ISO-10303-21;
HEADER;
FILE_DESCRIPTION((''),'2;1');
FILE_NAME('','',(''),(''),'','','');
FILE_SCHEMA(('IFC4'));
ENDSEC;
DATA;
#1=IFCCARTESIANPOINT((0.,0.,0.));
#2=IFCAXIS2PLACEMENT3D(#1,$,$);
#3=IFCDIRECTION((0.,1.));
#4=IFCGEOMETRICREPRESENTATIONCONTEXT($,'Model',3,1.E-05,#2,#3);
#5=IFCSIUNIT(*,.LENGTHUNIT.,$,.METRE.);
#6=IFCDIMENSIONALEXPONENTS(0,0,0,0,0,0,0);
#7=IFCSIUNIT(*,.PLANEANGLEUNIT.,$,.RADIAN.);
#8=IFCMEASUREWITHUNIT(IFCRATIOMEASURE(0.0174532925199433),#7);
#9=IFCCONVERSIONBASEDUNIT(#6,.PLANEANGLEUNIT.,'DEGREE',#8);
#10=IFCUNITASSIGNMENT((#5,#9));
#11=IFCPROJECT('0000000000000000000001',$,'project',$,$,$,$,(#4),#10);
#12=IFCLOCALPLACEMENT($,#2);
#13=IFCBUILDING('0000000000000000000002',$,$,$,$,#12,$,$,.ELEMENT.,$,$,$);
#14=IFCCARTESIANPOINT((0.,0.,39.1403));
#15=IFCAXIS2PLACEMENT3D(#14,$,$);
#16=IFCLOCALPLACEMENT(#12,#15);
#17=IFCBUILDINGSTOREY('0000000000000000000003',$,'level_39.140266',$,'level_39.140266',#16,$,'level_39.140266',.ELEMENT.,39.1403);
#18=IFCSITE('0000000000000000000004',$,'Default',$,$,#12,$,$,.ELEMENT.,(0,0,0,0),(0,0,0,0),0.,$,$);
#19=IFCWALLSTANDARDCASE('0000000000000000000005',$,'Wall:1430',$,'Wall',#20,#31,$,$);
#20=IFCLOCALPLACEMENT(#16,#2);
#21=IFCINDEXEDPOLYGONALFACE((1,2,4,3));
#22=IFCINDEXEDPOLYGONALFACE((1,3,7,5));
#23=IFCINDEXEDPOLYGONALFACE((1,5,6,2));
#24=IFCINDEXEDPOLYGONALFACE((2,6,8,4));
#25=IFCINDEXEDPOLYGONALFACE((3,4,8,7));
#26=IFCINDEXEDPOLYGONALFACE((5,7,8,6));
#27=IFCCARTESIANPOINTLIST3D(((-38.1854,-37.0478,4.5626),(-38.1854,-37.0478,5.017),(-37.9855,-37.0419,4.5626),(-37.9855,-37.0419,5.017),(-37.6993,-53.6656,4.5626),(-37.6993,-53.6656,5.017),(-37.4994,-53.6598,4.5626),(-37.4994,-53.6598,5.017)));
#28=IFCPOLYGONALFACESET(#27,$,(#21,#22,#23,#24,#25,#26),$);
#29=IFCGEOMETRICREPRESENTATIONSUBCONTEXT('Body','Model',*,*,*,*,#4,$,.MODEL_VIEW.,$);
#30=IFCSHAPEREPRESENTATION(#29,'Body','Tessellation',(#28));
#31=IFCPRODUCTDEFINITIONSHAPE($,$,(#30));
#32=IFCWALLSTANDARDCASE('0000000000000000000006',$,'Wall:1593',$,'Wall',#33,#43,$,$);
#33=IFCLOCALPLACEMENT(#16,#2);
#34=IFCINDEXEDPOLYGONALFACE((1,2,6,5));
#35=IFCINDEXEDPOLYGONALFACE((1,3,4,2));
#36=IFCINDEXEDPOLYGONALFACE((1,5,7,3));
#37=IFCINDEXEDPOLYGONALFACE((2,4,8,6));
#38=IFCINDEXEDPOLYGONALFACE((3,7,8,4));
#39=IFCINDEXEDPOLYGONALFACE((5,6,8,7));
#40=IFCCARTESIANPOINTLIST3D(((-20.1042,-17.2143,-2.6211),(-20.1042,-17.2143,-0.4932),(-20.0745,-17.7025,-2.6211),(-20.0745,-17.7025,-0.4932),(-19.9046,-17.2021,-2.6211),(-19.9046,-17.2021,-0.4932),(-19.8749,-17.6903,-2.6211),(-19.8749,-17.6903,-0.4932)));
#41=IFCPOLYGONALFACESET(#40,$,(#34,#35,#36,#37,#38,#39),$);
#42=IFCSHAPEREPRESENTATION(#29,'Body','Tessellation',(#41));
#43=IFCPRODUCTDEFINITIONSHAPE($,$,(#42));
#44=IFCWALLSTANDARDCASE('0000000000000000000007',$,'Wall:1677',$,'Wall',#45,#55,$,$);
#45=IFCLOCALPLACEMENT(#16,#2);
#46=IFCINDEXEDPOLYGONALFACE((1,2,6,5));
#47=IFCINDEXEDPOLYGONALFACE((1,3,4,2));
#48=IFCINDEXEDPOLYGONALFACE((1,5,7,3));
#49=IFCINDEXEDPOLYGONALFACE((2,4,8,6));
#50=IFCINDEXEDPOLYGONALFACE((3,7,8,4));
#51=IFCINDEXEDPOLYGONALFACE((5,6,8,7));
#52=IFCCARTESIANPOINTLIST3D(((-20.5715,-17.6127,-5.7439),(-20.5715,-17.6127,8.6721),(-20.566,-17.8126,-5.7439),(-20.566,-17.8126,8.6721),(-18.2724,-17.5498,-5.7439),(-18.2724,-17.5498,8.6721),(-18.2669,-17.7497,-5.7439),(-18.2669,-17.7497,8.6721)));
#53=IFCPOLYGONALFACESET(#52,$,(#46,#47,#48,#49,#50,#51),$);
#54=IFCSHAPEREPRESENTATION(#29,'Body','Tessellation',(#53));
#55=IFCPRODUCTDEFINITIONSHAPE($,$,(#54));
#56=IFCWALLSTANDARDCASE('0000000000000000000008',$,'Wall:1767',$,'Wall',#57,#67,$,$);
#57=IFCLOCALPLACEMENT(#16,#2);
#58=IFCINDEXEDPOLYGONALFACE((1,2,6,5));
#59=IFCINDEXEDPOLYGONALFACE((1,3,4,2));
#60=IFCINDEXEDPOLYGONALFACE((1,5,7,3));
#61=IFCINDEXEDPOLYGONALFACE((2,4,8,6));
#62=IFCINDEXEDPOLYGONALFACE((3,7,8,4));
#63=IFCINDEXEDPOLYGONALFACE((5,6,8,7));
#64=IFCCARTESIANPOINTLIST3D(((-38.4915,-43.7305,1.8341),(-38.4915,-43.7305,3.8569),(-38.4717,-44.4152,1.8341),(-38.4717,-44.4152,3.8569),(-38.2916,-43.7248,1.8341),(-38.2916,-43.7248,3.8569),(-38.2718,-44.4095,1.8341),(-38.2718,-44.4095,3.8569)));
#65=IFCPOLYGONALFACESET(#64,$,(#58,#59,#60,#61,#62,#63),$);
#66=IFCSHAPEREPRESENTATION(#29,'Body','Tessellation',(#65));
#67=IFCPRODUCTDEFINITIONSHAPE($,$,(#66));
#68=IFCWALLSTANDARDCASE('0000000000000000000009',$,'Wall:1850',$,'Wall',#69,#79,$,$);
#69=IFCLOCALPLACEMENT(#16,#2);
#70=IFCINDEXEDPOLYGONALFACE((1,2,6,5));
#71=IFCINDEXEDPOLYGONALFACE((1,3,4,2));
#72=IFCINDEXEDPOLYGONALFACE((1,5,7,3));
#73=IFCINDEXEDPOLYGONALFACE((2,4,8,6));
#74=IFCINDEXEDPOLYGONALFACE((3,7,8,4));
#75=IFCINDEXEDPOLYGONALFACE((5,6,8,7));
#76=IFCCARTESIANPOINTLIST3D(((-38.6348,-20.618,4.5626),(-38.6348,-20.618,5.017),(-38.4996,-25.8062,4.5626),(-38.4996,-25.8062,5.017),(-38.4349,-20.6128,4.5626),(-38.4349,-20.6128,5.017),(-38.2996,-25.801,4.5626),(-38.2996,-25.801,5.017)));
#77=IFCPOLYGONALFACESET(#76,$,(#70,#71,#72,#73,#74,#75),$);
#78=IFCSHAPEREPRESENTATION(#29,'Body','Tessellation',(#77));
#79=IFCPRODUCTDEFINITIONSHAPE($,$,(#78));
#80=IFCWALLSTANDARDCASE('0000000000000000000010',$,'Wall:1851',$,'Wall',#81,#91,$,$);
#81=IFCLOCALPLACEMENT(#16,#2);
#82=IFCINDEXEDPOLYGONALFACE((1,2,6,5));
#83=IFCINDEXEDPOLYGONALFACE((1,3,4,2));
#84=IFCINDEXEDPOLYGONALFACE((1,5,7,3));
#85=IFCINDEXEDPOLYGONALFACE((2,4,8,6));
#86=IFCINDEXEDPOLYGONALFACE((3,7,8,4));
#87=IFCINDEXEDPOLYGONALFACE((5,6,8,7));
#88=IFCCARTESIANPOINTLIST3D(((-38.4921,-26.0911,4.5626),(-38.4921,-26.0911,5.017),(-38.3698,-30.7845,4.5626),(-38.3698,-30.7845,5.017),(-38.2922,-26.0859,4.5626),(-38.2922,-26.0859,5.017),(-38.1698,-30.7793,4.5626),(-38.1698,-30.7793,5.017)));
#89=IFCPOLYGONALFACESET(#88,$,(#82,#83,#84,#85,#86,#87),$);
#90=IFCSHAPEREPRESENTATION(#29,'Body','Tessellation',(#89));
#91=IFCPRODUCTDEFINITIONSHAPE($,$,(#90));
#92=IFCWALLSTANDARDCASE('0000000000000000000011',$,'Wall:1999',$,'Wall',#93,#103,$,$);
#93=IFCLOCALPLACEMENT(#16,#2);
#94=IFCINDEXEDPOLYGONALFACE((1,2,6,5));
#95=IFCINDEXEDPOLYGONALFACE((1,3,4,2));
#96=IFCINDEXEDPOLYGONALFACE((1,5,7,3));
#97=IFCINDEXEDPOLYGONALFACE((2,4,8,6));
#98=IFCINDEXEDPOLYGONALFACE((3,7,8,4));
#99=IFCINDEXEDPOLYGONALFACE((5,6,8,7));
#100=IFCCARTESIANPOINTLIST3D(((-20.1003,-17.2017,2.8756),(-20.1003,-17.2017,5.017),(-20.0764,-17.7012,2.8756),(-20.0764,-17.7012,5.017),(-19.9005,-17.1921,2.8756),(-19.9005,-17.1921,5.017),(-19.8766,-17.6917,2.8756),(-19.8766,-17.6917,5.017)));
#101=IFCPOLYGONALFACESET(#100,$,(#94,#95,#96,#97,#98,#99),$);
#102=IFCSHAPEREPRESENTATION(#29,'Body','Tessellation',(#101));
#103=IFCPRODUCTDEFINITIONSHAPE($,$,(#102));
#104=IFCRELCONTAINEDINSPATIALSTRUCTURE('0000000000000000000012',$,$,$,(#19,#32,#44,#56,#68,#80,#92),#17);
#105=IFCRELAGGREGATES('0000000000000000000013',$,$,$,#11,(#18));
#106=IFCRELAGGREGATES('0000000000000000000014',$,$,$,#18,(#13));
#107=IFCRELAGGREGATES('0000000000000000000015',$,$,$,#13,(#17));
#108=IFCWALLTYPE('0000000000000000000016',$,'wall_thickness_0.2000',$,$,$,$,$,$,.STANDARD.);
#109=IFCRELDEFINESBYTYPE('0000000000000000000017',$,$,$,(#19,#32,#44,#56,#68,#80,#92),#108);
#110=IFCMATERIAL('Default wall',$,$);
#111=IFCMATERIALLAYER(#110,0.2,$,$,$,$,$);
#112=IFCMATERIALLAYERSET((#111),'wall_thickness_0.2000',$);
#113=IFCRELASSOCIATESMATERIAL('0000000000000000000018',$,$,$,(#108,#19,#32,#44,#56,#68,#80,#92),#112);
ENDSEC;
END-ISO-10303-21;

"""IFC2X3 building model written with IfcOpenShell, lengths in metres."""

from ifc_helpers import new_model, entity, si_unit, converted_unit, direction, frame, origin, place, context, subcontext, project, spatial, polyline, outline, extrude, material, layer, layer_set, layer_usage, type_object, element, save


model = new_model("IFC2X3")

# Units and contexts
model_context = context("Model", 3, precision=1e-05, world=origin(), true_north=direction((0.0, 1.0)))
body_context = subcontext(model_context, "Body", "Model", "MODEL_VIEW")
ifc_project = project(units=[si_unit("LENGTHUNIT", "METRE"), converted_unit("PLANEANGLEUNIT", "DEGREE", entity("IfcRatioMeasure", 0.0174532925199433), si_unit("PLANEANGLEUNIT", "RADIAN"), dimensions=[0, 0, 0, 0, 0, 0, 0])], contexts=[model_context])

# Site, building, storey
placement_1 = place(None, origin())
site = spatial("IfcSite", under=ifc_project, at=placement_1, Name="Default", CompositionType="ELEMENT", RefLatitude=(0, 0, 0, 0), RefLongitude=(0, 0, 0, 0), RefElevation=0.0)
building = spatial("IfcBuilding", under=site, at=placement_1, CompositionType="ELEMENT")
storey_placement = place(placement_1, frame((0.0, 0.0, 39.1403)))
storey = spatial("IfcBuildingStorey", under=building, at=storey_placement, Name="level_39.140266", ObjectType="level_39.140266", LongName="level_39.140266", CompositionType="ELEMENT", Elevation=39.1403)

# Shared definitions
ifc_material_1 = material(Name="Default wall")
ifc_layer = layer(ifc_material_1, 0.2)
ifc_layer_set = layer_set([ifc_layer], Name="wall_thickness_0.2000")
ifc_layer_usage = layer_usage(ifc_layer_set, "AXIS2", "POSITIVE", -0.1)
wall_type = type_object("IfcWallType", Name="wall_thickness_0.2000", PredefinedType="STANDARD", material=ifc_layer_set)

# Walls
placement_2 = place(placement_1, frame((0.0, 0.0, 43.7029)))
wall_1_placement = place(placement_2, frame((-38.0854, -37.0448, 0.0), z_axis=(0.0, 0.0, 1.0), x_axis=(0.029241, -0.999572, 0.0)))
element("IfcWallStandardCase", 1, at=wall_1_placement, inside=storey, type_object=wall_type, material=ifc_layer_usage, Name="Wall:1430", ObjectType="Wall", context=body_context, shape_type="SweptSolid", body=[
    extrude(outline(polyline([(16.625, -0.1), (16.625, 0.1), (0.0, 0.1), (0.0, -0.1), (16.625, -0.1)])), origin(), (0.0, 0.0, 1.0), 0.4544),
])
placement_3 = place(placement_1, frame((0.0, 0.0, 36.5192)))
wall_2_placement = place(placement_3, frame((-19.9747, -17.6964, 0.0), z_axis=(0.0, 0.0, 1.0), x_axis=(-0.060737, 0.998154, 0.0)))
element("IfcWallStandardCase", 2, at=wall_2_placement, inside=storey, type_object=wall_type, material=ifc_layer_usage, Name="Wall:1593", ObjectType="Wall", context=body_context, shape_type="SweptSolid", body=[
    extrude(outline(polyline([(0.4891, -0.1), (0.4891, 0.1), (0.0, 0.1), (0.0, -0.1), (0.4891, -0.1)])), origin(), (0.0, 0.0, 1.0), 2.1279),
])
placement_4 = place(placement_1, frame((0.0, 0.0, 33.3964)))
wall_3_placement = place(placement_4, frame((-18.2696, -17.6497, 0.0), z_axis=(0.0, 0.0, 1.0), x_axis=(-0.999625, -0.027366, 0.0)))
element("IfcWallStandardCase", 3, at=wall_3_placement, inside=storey, type_object=wall_type, material=ifc_layer_usage, Name="Wall:1677", ObjectType="Wall", context=body_context, shape_type="SweptSolid", body=[
    extrude(outline(polyline([(2.3, -0.1), (2.3, 0.1), (0.0, 0.1), (0.0, -0.1), (2.3, -0.1)])), origin(), (0.0, 0.0, 1.0), 14.416),
])
placement_5 = place(placement_1, frame((0.0, 0.0, 40.9744)))
wall_4_placement = place(placement_5, frame((-38.3718, -44.4124, 0.0), z_axis=(0.0, 0.0, 1.0), x_axis=(-0.028836, 0.999584, 0.0)))
element("IfcWallStandardCase", 4, at=wall_4_placement, inside=storey, type_object=wall_type, material=ifc_layer_usage, Name="Wall:1767", ObjectType="Wall", context=body_context, shape_type="SweptSolid", body=[
    extrude(outline(polyline([(0.685, -0.1), (0.685, 0.1), (0.0, 0.1), (0.0, -0.1), (0.685, -0.1)])), origin(), (0.0, 0.0, 1.0), 2.0228),
])
placement_6 = place(placement_1, frame((0.0, 0.0, 43.7029)))
wall_5_placement = place(placement_6, frame((-38.5349, -20.6154, 0.0), z_axis=(0.0, 0.0, 1.0), x_axis=(0.026064, -0.99966, 0.0)))
element("IfcWallStandardCase", 5, at=wall_5_placement, inside=storey, type_object=wall_type, material=ifc_layer_usage, Name="Wall:1850", ObjectType="Wall", context=body_context, shape_type="SweptSolid", body=[
    extrude(outline(polyline([(5.19, -0.1), (5.19, 0.1), (0.0, 0.1), (0.0, -0.1), (5.19, -0.1)])), origin(), (0.0, 0.0, 1.0), 0.4544),
])
placement_7 = place(placement_1, frame((0.0, 0.0, 43.7029)))
wall_6_placement = place(placement_7, frame((-38.3922, -26.0885, 0.0), z_axis=(0.0, 0.0, 1.0), x_axis=(0.026064, -0.99966, 0.0)))
element("IfcWallStandardCase", 6, at=wall_6_placement, inside=storey, type_object=wall_type, material=ifc_layer_usage, Name="Wall:1851", ObjectType="Wall", context=body_context, shape_type="SweptSolid", body=[
    extrude(outline(polyline([(4.695, -0.1), (4.695, 0.1), (0.0, 0.1), (0.0, -0.1), (4.695, -0.1)])), origin(), (0.0, 0.0, 1.0), 0.4544),
])
placement_8 = place(placement_1, frame((0.0, 0.0, 42.0159)))
wall_7_placement = place(placement_8, frame((-20.0004, -17.1969, 0.0), z_axis=(0.0, 0.0, 1.0), x_axis=(0.047736, -0.99886, 0.0)))
element("IfcWallStandardCase", 7, at=wall_7_placement, inside=storey, type_object=wall_type, material=ifc_layer_usage, Name="Wall:1999", ObjectType="Wall", context=body_context, shape_type="SweptSolid", body=[
    extrude(outline(polyline([(0.5001, -0.1), (0.5001, 0.1), (0.0, 0.1), (0.0, -0.1), (0.5001, -0.1)])), origin(), (0.0, 0.0, 1.0), 2.1414),
])

save(model, "model.ifc")
